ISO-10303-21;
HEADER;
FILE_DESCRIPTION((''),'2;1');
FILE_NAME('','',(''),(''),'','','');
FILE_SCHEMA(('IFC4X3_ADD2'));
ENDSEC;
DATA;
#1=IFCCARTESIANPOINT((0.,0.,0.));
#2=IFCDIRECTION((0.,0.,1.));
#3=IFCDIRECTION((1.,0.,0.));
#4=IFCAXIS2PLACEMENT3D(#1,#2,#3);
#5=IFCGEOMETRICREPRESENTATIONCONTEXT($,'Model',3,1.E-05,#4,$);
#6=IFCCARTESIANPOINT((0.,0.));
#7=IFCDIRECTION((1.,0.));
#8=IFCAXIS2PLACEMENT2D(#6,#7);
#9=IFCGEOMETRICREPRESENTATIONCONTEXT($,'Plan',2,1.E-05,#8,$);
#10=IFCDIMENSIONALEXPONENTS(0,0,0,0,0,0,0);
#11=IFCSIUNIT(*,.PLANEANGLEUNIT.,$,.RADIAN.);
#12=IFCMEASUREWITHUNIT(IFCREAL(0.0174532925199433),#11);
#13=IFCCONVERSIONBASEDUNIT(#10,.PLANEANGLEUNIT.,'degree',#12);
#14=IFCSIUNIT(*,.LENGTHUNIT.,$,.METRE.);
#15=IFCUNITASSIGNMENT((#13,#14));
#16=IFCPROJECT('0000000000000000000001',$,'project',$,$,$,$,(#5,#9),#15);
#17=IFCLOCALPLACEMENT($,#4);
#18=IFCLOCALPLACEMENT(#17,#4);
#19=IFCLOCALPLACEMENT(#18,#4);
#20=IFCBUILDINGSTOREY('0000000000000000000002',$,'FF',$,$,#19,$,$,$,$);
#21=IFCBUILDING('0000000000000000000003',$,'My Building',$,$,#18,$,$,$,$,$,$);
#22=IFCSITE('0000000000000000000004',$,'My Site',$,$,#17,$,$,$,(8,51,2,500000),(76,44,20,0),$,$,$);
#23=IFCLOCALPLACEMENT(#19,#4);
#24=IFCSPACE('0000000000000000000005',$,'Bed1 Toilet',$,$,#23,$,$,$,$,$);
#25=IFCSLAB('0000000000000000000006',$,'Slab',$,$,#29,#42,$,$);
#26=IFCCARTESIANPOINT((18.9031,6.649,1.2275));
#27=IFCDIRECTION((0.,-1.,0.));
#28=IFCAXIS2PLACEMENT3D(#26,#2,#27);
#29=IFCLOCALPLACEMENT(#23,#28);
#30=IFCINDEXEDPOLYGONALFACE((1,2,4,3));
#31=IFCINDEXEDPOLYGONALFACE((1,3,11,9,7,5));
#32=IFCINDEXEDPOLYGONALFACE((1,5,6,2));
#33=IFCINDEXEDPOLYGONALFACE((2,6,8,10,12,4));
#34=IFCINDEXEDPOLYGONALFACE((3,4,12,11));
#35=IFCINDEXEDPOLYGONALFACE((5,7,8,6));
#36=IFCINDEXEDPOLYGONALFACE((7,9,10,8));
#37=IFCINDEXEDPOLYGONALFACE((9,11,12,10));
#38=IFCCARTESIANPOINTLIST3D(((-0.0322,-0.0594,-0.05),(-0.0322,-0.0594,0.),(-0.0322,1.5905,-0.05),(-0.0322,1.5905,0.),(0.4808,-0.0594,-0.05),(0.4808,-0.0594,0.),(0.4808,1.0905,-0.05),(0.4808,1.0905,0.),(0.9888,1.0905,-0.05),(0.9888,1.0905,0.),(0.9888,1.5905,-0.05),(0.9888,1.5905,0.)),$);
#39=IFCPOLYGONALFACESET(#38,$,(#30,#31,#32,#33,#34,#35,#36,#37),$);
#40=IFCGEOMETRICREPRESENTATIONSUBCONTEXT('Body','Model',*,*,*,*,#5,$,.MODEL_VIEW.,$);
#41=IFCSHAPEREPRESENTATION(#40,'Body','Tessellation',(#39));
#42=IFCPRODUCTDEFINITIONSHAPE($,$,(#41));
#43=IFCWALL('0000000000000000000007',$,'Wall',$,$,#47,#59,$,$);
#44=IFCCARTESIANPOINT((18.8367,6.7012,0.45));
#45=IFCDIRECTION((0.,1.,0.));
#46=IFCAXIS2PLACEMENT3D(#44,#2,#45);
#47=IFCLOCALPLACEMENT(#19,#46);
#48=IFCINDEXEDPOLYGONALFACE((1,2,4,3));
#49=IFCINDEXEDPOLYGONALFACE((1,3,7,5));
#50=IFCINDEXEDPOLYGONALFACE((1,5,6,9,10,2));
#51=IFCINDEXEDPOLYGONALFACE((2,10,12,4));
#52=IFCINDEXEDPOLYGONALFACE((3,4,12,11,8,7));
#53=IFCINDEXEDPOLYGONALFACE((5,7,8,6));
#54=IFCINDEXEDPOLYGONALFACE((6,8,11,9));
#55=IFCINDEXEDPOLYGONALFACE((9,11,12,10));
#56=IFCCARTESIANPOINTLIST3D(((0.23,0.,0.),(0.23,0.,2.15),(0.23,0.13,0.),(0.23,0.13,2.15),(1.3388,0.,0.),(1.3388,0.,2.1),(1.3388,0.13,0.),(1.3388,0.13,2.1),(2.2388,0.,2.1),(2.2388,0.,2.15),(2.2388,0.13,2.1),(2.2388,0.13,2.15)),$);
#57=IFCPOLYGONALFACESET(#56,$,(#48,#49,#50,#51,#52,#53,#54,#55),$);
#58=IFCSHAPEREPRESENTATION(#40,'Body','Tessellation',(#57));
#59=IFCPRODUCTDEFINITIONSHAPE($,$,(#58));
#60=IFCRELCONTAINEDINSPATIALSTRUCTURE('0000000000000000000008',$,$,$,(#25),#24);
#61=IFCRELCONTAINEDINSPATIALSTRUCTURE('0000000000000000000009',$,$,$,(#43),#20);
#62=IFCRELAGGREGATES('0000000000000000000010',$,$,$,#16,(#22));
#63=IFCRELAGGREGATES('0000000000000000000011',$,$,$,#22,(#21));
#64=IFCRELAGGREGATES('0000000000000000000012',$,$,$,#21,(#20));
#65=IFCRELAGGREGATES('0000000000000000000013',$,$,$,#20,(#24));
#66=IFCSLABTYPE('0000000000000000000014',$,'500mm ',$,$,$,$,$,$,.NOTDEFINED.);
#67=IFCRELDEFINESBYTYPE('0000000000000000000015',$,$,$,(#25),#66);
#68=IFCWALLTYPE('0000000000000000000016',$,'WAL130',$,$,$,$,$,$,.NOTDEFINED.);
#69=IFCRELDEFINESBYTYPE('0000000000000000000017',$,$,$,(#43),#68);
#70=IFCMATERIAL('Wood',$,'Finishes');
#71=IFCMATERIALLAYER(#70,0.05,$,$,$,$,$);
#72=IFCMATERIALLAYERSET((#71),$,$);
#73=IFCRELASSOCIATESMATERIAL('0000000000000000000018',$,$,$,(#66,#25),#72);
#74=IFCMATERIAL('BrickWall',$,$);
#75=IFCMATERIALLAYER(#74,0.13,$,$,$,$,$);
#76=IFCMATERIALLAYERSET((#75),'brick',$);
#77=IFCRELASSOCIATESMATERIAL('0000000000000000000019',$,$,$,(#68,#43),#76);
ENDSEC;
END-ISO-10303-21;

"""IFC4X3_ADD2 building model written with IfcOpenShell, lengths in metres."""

from ifc_helpers import new_model, entity, si_unit, converted_unit, frame, origin_with_axes, origin_2d_with_axis, place, context, subcontext, project, spatial, line, indexed_curve, outline, extrude, source, transform, mapped, material, layer, layer_set, layer_usage, type_object, element, save


model = new_model("IFC4X3_ADD2")

# Units and contexts
model_context = context("Model", 3, precision=1e-05, world=origin_with_axes())
plan_context = context("Plan", 2, precision=1e-05, world=origin_2d_with_axis())
body_context_1 = subcontext(model_context, "Body", "Model", "MODEL_VIEW")
ifc_project = project(units=[converted_unit("PLANEANGLEUNIT", "degree", entity("IfcReal", 0.0174532925199433), si_unit("PLANEANGLEUNIT", "RADIAN"), dimensions=[0, 0, 0, 0, 0, 0, 0]), si_unit("LENGTHUNIT", "METRE")], contexts=[model_context, plan_context])

# Site, building, storey
site_placement = place(None, origin_with_axes())
site = spatial("IfcSite", under=ifc_project, at=site_placement, Name="My Site", RefLatitude=(8, 51, 2, 500000), RefLongitude=(76, 44, 20, 0))
building_placement = place(site_placement, origin_with_axes())
building = spatial("IfcBuilding", under=site, at=building_placement, Name="My Building")
storey_placement = place(building_placement, origin_with_axes())
storey = spatial("IfcBuildingStorey", under=building, at=storey_placement, Name="FF")

# Shared definitions
space_1_placement = place(storey_placement, origin_with_axes())
space_1 = spatial("IfcSpace", under=storey, at=space_1_placement, Name="Bed1 Toilet")

# Slab
ifc_material_1 = material(Name="Wood", Category="Finishes")
ifc_layer_1 = layer(ifc_material_1, 0.05)
ifc_layer_set_1 = layer_set([ifc_layer_1])
ifc_layer_usage_1 = layer_usage(ifc_layer_set_1, "AXIS3", "POSITIVE", -0.05)
slab_type = type_object("IfcSlabType", Name="500mm ", PredefinedType="NOTDEFINED", material=ifc_layer_set_1)
slab_placement = place(space_1_placement, frame((18.9031, 6.649, 1.2275), z_axis=(0.0, 0.0, 1.0), x_axis=(0.0, -1.0, 0.0)))
element("IfcSlab", 1, at=slab_placement, inside=space_1, type_object=slab_type, material=ifc_layer_usage_1, Name="Slab", context=body_context_1, shape_type="SweptSolid", body=[
    extrude(outline(indexed_curve([(0.9888, 1.5905), (0.9888, 1.0905), (0.4808, 1.0905), (0.4808, -0.0594), (-0.0322, -0.0594), (-0.0322, 1.5905), (0.9888, 1.5905)])), frame((0.0, 0.0, -0.05), z_axis=(0.0, 0.0, 1.0), x_axis=(1.0, 0.0, 0.0)), (0.0, 0.0, 1.0), 0.05),
])

# Shared definitions
ifc_material_2 = material(Name="BrickWall")

# Wall, opening
ifc_layer_2 = layer(ifc_material_2, 0.13)
ifc_layer_set_2 = layer_set([ifc_layer_2], Name="brick")
ifc_layer_usage_2 = layer_usage(ifc_layer_set_2, "AXIS2", "POSITIVE", 0.0)
wall_type_1 = type_object("IfcWallType", Name="WAL130", PredefinedType="NOTDEFINED", material=ifc_layer_set_2)
wall_1_placement = place(storey_placement, frame((18.8367, 6.7012, 0.45), z_axis=(0.0, 0.0, 1.0), x_axis=(0.0, 1.0, 0.0)))
wall_1 = element("IfcWall", 2, at=wall_1_placement, inside=storey, type_object=wall_type_1, material=ifc_layer_usage_2, Name="Wall", context=body_context_1, shape_type="SweptSolid", body=[
    extrude(outline(indexed_curve([(0.23, 0.0), (0.23, 0.13), (2.2388, 0.13), (2.2388, 0.0)], segments=[line(1, 2, 3, 4, 1)])), origin_with_axes(), (0.0, 0.0, 1.0), 2.15),
])
shared_shape_1 = source(origin_with_axes(), body_context_1, "Body", "SweptSolid", [
    extrude(outline(indexed_curve([(0.0, 0.0), (0.9, 0.0), (0.9, 2.1), (0.0, 2.1)], segments=[line(1, 2, 3, 4, 1)])), frame((0.0, -0.6, 0.0), z_axis=(0.0, -1.0, 0.0), x_axis=(1.0, 0.0, 0.0)), (0.0, 0.0, -1.0), 1.2),
])
opening_1_placement = place(wall_1_placement, frame((2.2388, 0.0989, 0.0), z_axis=(0.0, 0.0, 1.0), x_axis=(-1.0, 0.0, 0.0)))
element("IfcOpeningElement", 3, at=opening_1_placement, cuts=wall_1, PredefinedType="OPENING", context=body_context_1, shape_type="MappedRepresentation", body=[
    mapped(shared_shape_1, transform((0.0, 0.0, 0.0), x_axis=(1.0, 0.0, 0.0), y_axis=(0.0, 1.0, 0.0), z_axis=(0.0, 0.0, 1.0), scale=1.0)),
])

save(model, "model.ifc")
